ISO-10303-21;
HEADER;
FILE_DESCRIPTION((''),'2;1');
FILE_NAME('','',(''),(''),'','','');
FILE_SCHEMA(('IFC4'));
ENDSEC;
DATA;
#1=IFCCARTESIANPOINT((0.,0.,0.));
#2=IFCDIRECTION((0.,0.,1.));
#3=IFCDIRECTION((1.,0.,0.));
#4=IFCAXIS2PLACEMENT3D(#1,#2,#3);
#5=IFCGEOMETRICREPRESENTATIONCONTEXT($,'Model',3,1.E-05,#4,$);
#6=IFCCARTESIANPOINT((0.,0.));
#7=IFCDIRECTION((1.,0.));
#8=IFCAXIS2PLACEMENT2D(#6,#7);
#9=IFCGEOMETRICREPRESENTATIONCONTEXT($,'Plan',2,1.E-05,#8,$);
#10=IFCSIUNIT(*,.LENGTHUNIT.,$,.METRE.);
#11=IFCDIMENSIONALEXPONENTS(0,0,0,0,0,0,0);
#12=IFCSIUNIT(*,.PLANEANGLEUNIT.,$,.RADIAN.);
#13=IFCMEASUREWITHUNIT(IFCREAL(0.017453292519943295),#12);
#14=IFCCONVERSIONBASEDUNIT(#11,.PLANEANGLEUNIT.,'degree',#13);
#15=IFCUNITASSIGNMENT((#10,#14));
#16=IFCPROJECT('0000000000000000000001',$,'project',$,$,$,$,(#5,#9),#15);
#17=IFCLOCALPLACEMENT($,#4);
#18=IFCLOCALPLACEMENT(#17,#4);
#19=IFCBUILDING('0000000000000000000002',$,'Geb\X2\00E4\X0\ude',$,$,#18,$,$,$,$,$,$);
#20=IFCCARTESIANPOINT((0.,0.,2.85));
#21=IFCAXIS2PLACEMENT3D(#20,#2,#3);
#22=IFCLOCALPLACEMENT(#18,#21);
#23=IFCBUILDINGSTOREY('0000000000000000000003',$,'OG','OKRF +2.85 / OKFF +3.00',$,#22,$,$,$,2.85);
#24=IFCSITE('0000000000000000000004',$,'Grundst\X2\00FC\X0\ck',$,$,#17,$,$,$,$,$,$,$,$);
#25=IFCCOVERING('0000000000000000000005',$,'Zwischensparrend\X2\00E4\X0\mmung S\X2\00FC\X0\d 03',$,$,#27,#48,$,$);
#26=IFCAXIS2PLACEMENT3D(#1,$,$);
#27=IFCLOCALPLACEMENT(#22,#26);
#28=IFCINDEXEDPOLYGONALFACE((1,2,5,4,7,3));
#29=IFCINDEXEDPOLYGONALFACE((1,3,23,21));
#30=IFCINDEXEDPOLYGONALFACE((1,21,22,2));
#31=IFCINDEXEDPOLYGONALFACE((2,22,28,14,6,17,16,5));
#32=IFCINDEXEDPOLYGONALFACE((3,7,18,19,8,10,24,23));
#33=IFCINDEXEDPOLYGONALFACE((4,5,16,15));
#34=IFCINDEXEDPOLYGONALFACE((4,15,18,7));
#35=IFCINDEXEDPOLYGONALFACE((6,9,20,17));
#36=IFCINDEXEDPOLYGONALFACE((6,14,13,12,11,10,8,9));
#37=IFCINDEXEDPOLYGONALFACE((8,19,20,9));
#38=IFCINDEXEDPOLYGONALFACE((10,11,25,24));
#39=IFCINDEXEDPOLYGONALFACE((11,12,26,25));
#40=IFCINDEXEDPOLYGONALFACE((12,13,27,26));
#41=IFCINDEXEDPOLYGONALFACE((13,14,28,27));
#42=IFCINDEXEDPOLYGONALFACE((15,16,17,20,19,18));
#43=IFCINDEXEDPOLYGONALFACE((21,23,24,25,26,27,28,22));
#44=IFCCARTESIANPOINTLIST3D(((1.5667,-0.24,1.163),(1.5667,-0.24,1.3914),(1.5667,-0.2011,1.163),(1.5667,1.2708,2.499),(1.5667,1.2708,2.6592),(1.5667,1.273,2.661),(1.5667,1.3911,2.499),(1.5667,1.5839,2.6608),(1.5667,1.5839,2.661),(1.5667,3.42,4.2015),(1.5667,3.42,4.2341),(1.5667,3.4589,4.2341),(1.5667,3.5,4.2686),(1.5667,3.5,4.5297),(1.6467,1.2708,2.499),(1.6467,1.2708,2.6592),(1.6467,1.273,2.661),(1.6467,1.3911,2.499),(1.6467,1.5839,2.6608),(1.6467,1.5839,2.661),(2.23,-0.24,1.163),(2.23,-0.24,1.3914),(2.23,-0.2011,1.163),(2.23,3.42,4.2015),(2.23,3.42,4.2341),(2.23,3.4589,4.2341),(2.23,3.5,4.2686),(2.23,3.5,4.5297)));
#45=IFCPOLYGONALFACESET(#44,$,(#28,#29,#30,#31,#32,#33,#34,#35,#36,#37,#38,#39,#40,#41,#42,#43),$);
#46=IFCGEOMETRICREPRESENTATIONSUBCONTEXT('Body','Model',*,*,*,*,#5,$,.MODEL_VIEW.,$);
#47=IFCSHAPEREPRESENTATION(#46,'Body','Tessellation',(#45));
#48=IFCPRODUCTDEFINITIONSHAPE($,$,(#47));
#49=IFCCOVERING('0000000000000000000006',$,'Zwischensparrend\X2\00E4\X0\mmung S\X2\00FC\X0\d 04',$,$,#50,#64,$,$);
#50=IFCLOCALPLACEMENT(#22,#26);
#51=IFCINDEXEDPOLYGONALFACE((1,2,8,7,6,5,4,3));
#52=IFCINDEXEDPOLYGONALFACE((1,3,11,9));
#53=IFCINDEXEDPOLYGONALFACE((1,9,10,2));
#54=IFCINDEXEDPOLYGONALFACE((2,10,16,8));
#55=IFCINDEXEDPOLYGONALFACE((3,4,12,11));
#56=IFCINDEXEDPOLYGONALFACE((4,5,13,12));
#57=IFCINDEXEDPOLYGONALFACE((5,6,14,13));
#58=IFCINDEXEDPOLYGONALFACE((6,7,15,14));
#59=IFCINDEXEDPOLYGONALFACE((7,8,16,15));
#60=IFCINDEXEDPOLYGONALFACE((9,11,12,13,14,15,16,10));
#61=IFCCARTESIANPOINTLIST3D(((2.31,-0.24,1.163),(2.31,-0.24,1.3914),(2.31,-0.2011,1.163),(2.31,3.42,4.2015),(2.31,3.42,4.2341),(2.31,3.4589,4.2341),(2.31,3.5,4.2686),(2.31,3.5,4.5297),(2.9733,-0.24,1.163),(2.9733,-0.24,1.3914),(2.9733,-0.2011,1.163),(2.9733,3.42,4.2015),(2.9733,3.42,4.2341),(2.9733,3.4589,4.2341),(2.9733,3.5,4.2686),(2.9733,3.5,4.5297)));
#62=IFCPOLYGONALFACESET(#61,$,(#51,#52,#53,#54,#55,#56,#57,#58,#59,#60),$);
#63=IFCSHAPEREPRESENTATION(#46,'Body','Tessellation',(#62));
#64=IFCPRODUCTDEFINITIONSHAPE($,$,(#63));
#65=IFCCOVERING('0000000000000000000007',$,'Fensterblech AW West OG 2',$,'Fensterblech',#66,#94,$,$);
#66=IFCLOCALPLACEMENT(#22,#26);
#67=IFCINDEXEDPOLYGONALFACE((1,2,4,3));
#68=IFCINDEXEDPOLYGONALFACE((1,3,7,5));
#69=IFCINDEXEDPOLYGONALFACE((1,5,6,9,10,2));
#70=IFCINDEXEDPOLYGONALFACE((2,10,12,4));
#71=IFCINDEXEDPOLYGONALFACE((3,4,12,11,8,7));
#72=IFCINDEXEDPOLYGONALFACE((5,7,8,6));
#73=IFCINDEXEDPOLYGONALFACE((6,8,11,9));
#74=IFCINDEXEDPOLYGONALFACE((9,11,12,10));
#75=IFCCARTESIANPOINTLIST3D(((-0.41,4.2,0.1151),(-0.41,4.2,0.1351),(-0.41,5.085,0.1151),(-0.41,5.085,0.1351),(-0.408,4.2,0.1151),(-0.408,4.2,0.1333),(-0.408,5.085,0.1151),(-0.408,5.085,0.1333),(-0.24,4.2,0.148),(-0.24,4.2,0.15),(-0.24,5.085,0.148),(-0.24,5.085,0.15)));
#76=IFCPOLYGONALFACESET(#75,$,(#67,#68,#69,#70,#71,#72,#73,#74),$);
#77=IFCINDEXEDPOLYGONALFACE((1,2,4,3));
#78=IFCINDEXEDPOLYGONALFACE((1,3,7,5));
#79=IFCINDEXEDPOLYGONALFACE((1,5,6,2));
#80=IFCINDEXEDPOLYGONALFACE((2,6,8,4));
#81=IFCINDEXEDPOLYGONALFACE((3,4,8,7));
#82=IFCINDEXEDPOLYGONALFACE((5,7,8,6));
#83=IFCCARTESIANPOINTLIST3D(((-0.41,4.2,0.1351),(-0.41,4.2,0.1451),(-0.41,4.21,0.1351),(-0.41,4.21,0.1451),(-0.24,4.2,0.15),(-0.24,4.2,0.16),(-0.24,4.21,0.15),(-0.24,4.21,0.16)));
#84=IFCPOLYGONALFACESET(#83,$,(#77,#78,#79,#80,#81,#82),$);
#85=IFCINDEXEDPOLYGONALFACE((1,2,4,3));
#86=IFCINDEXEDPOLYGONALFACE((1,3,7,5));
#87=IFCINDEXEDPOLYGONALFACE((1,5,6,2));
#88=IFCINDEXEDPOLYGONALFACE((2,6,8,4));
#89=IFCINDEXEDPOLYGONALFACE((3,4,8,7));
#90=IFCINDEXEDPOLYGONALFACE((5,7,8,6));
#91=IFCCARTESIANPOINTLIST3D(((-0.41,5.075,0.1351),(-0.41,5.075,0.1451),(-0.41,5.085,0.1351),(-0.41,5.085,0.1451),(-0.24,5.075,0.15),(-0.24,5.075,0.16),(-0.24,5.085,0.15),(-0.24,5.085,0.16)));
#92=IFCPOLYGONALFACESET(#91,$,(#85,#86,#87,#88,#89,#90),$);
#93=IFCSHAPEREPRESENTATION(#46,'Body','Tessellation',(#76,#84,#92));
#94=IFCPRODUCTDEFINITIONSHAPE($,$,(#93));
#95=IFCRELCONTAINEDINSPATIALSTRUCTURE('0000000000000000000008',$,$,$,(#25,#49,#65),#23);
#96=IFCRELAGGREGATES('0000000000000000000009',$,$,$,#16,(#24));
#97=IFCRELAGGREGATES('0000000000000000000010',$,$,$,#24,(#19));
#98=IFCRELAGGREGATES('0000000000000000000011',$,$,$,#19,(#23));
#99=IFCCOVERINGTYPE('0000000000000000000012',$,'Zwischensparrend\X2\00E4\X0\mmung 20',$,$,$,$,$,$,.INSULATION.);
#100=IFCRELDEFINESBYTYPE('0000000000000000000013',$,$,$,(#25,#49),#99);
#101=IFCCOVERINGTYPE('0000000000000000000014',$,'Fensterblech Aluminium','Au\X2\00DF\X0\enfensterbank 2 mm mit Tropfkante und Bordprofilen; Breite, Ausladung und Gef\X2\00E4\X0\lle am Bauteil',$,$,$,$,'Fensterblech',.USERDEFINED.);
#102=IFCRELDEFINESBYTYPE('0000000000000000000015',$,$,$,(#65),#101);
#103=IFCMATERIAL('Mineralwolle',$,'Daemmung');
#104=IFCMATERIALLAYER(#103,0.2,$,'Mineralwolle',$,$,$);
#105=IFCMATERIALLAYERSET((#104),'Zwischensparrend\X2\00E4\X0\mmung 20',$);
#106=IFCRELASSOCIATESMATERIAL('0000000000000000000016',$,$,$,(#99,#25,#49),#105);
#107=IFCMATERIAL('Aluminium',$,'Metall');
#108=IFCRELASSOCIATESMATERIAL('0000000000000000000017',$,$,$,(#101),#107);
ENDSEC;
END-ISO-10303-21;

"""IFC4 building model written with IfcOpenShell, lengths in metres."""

from ifc_helpers import new_model, entity, si_unit, converted_unit, frame, origin_with_axes, origin_2d_with_axis, place, context, subcontext, project, spatial, polyline, outline, extrude, material, layer, layer_set, layer_usage, type_object, element, save


model = new_model("IFC4")

# Units and contexts
model_context = context("Model", 3, precision=1e-05, world=origin_with_axes())
plan_context = context("Plan", 2, precision=1e-05, world=origin_2d_with_axis())
body_context = subcontext(model_context, "Body", "Model", "MODEL_VIEW")
ifc_project = project(units=[si_unit("LENGTHUNIT", "METRE"), converted_unit("PLANEANGLEUNIT", "degree", entity("IfcReal", 0.017453292519943295), si_unit("PLANEANGLEUNIT", "RADIAN"), dimensions=[0, 0, 0, 0, 0, 0, 0])], contexts=[model_context, plan_context])

# Site, building, storey
site_placement = place(None, origin_with_axes())
site = spatial("IfcSite", under=ifc_project, at=site_placement, Name="Grundstück")
building_placement = place(site_placement, origin_with_axes())
building = spatial("IfcBuilding", under=site, at=building_placement, Name="Gebäude")
storey_placement = place(building_placement, frame((0.0, 0.0, 2.85), z_axis=(0.0, 0.0, 1.0), x_axis=(1.0, 0.0, 0.0)))
storey = spatial("IfcBuildingStorey", under=building, at=storey_placement, Name="OG", Description="OKRF +2.85 / OKFF +3.00", Elevation=2.85)

# Shared definitions
ifc_material_1 = material(Name="Mineralwolle", Category="Daemmung")
ifc_layer_1 = layer(ifc_material_1, 0.2, Name="Mineralwolle")
ifc_layer_set_1 = layer_set([ifc_layer_1], Name="Zwischensparrendämmung 20")
covering_type_1 = type_object("IfcCoveringType", Name="Zwischensparrendämmung 20", PredefinedType="INSULATION", material=ifc_layer_set_1)

# Covering, opening
ifc_layer_usage_1 = layer_usage(ifc_layer_set_1, "AXIS3", "POSITIVE", 0.0)
covering_1_placement = place(storey_placement, frame((1.5667, -0.24, 1.1304), z_axis=(0.0, -0.642788, 0.766044), x_axis=(1.0, 0.0, 0.0)))
covering_1 = element("IfcCovering", 1, at=covering_1_placement, inside=storey, type_object=covering_type_1, material=ifc_layer_usage_1, Name="Zwischensparrendämmung Süd 03", context=body_context, shape_type="SweptSolid", body=[
    extrude(outline(polyline([(0.021, 0.025), (0.0508, 0.0), (4.7778, 0.0), (4.7988, 0.025), (4.8286, 0.0), (4.8822, 0.0), (5.05, 0.2), (0.1678, 0.2), (0.021, 0.025)])), frame((0.0, 0.0, 0.0), z_axis=(1.0, 0.0, 0.0), x_axis=(0.0, 1.0, 0.0)), (0.0, 0.0, 1.0), 0.6633),
])
opening_1_placement = place(covering_1_placement, frame((-1.5667, -2.3747, -3.2034), z_axis=(0.0, 0.642788, 0.766044), x_axis=(1.0, 0.0, 0.0)))
element("IfcOpeningElement", 2, at=opening_1_placement, cuts=covering_1, PredefinedType="RECESS", context=body_context, shape_type="SweptSolid", body=[
    extrude(outline(polyline([(1.5667, 1.2708), (1.6467, 1.2708), (1.6467, 1.5839), (1.5667, 1.5839), (1.5667, 1.2708)])), frame((0.0, 0.0, 5.349), z_axis=(0.0, 0.0, 1.0), x_axis=(1.0, 0.0, 0.0)), (0.0, 0.0, 1.0), 0.162),
])

# Coverings
ifc_layer_usage_2 = layer_usage(ifc_layer_set_1, "AXIS3", "POSITIVE", 0.0)
covering_2_placement = place(storey_placement, frame((2.31, -0.24, 1.1304), z_axis=(0.0, -0.642788, 0.766044), x_axis=(1.0, 0.0, 0.0)))
element("IfcCovering", 3, at=covering_2_placement, inside=storey, type_object=covering_type_1, material=ifc_layer_usage_2, Name="Zwischensparrendämmung Süd 04", context=body_context, shape_type="SweptSolid", body=[
    extrude(outline(polyline([(0.021, 0.025), (0.0508, 0.0), (4.7778, 0.0), (4.7988, 0.025), (4.8286, 0.0), (4.8822, 0.0), (5.05, 0.2), (0.1678, 0.2), (0.021, 0.025)])), frame((0.0, 0.0, 0.0), z_axis=(1.0, 0.0, 0.0), x_axis=(0.0, 1.0, 0.0)), (0.0, 0.0, 1.0), 0.6633),
])
ifc_material_2 = material(Name="Aluminium", Category="Metall")
covering_type_2 = type_object("IfcCoveringType", Name="Fensterblech Aluminium", Description="Außenfensterbank 2 mm mit Tropfkante und Bordprofilen; Breite, Ausladung und Gefälle am Bauteil", ElementType="Fensterblech", PredefinedType="USERDEFINED", material=ifc_material_2)
covering_3_placement = place(storey_placement, frame((0.0, 0.0, 0.0), z_axis=(0.0, 0.0, 1.0), x_axis=(0.0, 1.0, 0.0)))
element("IfcCovering", 4, at=covering_3_placement, inside=storey, type_object=covering_type_2, Name="Fensterblech AW West OG 2", ObjectType="Fensterblech", context=body_context, shape_type="SweptSolid", body=[
    extrude(outline(polyline([(0.24, 0.148), (0.408, 0.1333), (0.408, 0.1151), (0.41, 0.1151), (0.41, 0.1351), (0.24, 0.15), (0.24, 0.148)])), frame((4.2, 0.0, 0.0), z_axis=(1.0, 0.0, 0.0), x_axis=(0.0, 1.0, 0.0)), (0.0, 0.0, 1.0), 0.885),
    extrude(outline(polyline([(0.24, 0.15), (0.41, 0.1351), (0.41, 0.1451), (0.24, 0.16), (0.24, 0.15)])), frame((4.2, 0.0, 0.0), z_axis=(1.0, 0.0, 0.0), x_axis=(0.0, 1.0, 0.0)), (0.0, 0.0, 1.0), 0.01),
    extrude(outline(polyline([(0.24, 0.15), (0.41, 0.1351), (0.41, 0.1451), (0.24, 0.16), (0.24, 0.15)])), frame((5.075, 0.0, 0.0), z_axis=(1.0, 0.0, 0.0), x_axis=(0.0, 1.0, 0.0)), (0.0, 0.0, 1.0), 0.01),
])

save(model, "model.ifc")
